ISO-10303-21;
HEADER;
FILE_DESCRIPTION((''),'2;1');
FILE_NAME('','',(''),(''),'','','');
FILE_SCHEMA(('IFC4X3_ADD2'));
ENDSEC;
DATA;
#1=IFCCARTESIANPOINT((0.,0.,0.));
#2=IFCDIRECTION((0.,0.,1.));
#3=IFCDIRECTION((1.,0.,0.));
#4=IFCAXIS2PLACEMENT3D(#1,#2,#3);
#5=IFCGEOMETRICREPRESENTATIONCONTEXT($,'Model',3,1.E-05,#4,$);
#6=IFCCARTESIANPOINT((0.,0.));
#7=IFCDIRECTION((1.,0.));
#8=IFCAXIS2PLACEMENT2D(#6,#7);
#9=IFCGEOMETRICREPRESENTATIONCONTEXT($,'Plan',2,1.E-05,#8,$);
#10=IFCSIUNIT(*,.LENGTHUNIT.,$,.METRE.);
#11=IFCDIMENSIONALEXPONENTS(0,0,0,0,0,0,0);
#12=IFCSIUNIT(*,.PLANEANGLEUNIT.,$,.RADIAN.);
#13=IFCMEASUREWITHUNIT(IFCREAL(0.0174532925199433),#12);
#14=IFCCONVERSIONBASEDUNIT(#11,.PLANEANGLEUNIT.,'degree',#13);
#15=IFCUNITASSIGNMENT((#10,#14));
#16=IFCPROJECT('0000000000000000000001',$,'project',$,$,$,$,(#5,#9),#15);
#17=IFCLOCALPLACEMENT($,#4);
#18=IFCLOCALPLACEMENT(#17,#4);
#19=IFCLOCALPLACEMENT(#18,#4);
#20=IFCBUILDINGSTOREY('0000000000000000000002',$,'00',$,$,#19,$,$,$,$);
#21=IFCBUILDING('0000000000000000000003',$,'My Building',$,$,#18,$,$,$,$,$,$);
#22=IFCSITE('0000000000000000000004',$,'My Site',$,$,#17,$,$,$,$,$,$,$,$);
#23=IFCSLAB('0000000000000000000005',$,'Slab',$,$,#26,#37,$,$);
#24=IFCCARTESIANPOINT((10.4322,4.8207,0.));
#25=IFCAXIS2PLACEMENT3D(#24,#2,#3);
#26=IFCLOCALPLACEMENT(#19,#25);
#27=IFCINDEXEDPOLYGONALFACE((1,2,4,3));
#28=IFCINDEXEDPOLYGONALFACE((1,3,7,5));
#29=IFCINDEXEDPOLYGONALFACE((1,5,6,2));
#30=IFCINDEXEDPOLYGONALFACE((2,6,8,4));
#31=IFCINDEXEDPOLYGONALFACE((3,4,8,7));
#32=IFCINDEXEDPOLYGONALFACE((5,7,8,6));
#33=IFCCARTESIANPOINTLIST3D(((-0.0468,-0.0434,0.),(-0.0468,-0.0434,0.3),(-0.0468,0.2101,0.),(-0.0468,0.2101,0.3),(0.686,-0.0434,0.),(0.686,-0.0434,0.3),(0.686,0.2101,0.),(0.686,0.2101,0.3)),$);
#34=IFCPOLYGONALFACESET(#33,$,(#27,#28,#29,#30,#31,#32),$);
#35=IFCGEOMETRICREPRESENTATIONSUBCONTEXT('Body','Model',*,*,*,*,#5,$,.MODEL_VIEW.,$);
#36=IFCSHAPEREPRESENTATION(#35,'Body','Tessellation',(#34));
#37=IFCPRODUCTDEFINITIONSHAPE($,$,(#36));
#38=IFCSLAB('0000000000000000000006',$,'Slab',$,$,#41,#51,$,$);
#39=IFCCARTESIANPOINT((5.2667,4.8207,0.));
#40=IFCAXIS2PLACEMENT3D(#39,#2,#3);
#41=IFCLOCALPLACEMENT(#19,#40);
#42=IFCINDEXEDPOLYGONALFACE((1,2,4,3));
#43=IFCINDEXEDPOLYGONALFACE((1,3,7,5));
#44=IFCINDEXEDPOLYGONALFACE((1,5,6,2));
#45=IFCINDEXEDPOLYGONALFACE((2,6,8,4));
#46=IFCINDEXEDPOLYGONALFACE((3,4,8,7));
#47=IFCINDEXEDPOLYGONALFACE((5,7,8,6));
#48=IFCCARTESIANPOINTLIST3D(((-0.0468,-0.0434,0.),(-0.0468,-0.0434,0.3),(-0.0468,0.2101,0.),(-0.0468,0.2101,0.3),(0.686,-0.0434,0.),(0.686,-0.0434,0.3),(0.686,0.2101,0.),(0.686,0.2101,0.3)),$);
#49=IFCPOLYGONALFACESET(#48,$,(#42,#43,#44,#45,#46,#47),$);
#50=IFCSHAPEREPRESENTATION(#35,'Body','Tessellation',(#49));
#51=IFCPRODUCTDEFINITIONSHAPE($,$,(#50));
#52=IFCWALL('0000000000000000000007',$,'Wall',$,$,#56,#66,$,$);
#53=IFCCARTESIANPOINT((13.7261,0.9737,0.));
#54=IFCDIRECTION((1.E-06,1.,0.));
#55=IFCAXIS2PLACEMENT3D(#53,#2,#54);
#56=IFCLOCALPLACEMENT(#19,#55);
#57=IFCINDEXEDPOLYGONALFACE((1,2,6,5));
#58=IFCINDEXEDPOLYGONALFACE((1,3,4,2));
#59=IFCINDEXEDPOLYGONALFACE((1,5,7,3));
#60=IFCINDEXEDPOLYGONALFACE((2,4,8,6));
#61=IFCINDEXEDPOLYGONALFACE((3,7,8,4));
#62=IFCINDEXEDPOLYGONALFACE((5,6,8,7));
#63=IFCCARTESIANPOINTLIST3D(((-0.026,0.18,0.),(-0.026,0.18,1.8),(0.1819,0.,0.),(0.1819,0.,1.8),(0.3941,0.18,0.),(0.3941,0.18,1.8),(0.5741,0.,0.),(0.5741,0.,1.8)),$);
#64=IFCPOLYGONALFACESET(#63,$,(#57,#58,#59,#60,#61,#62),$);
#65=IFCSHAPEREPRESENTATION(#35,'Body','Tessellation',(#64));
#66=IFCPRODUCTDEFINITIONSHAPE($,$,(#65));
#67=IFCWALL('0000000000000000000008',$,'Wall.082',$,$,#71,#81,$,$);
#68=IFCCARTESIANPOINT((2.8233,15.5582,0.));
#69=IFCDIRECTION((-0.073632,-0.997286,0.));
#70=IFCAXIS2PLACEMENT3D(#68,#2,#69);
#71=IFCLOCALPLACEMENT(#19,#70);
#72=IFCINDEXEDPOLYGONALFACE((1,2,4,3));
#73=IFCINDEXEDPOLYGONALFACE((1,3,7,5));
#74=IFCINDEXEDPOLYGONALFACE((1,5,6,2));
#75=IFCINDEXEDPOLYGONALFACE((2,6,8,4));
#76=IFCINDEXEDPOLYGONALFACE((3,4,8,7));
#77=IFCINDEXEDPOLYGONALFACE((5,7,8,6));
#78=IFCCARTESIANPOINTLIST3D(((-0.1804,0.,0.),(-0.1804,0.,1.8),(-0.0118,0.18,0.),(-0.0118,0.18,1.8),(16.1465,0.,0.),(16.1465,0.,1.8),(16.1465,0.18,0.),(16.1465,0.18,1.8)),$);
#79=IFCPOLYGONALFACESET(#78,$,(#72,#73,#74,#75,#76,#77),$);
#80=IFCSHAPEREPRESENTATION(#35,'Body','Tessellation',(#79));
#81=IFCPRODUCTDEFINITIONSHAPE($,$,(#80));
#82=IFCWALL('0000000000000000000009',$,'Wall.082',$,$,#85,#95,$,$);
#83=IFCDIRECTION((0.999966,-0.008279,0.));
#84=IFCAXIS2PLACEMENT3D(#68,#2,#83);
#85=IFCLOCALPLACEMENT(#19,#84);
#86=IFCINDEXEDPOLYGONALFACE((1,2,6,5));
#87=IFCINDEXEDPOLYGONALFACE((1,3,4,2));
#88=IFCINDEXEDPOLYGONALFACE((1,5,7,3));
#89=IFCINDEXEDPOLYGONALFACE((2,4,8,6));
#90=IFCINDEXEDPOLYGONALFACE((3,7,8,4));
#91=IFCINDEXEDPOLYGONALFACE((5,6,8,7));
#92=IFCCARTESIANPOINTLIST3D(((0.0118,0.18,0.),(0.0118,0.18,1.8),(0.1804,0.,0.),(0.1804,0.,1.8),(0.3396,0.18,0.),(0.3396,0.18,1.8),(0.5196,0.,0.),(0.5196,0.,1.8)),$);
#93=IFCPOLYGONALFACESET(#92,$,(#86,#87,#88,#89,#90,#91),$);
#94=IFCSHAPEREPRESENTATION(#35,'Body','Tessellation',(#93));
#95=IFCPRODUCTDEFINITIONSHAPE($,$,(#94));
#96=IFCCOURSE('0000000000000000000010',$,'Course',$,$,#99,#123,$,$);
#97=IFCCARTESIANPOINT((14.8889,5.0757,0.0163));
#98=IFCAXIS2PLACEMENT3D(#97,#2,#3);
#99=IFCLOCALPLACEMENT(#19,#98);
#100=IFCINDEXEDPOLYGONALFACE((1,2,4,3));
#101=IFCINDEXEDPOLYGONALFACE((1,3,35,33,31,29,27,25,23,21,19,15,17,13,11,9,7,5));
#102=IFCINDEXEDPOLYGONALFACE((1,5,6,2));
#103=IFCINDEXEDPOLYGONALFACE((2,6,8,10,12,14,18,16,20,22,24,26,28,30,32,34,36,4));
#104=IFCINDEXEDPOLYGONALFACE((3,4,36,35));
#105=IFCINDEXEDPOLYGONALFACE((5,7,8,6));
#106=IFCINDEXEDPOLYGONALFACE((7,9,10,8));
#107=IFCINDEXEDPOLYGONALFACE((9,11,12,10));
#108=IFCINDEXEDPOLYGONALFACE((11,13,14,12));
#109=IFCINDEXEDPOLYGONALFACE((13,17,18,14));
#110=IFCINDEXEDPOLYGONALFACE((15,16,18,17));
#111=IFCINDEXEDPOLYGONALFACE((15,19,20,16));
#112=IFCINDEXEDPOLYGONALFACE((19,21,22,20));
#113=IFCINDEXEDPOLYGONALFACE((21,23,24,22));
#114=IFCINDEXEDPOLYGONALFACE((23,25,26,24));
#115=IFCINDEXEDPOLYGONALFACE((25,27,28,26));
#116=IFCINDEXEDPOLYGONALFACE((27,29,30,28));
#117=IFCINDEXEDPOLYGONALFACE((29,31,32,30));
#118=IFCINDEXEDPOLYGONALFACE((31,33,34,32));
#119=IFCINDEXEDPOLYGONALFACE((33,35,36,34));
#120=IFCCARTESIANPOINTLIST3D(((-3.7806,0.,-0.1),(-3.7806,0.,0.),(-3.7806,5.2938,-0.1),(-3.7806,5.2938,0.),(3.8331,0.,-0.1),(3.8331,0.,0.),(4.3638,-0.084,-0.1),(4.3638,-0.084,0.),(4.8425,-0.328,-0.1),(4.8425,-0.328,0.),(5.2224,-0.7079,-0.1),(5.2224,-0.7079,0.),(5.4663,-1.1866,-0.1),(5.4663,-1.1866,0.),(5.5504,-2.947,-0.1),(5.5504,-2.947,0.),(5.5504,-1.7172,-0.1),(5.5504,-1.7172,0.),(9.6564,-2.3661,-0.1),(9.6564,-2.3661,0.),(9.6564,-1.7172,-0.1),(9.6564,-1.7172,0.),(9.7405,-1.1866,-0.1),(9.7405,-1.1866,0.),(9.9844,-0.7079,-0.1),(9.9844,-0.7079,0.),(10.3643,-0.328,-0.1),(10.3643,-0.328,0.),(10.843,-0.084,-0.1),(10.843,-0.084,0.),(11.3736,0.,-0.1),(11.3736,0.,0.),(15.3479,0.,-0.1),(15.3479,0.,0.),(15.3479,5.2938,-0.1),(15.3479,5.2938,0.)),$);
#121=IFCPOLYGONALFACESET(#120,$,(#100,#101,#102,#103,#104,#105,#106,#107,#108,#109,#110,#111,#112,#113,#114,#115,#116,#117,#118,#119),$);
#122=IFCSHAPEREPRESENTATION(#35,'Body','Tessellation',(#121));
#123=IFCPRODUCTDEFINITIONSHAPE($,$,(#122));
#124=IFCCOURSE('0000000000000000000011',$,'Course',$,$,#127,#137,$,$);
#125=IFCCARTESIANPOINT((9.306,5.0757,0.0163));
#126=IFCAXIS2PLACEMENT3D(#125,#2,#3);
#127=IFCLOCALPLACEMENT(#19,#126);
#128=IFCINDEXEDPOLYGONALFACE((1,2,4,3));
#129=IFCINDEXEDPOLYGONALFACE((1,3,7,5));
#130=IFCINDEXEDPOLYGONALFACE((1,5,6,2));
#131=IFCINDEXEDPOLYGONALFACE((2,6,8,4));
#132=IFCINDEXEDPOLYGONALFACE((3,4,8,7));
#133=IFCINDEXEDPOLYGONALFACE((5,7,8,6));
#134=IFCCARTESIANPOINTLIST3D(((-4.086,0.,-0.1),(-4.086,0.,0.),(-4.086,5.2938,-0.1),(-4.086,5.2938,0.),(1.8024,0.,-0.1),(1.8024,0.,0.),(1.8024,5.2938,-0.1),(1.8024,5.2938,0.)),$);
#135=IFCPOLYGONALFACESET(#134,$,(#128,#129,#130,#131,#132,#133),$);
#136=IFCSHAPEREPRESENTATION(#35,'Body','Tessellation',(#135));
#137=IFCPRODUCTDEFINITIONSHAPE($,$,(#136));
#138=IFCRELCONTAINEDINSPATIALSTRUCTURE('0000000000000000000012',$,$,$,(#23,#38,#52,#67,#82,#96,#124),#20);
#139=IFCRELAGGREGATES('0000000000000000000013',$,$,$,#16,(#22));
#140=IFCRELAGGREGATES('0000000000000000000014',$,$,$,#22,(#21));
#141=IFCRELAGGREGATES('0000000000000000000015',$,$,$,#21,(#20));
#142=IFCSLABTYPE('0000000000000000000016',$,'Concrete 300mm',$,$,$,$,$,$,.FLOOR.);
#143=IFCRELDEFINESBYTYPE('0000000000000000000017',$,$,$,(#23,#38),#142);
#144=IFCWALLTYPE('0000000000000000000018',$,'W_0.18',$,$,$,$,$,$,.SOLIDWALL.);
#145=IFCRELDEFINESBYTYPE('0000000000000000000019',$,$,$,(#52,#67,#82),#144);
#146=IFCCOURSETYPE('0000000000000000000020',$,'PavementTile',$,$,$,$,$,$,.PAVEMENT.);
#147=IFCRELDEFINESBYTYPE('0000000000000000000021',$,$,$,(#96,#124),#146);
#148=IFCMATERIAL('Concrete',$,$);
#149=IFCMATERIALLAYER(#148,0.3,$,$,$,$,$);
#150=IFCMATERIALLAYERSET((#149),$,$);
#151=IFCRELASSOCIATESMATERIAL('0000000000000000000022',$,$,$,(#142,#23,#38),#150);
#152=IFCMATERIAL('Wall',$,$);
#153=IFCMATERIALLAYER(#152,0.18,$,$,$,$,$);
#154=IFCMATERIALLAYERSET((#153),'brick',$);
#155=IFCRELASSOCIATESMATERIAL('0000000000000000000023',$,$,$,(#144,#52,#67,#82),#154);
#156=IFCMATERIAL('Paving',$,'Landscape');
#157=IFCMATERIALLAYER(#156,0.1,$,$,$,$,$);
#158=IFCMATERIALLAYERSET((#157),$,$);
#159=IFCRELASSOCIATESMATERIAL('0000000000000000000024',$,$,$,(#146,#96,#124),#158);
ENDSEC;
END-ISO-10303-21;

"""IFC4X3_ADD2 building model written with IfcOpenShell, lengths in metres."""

from ifc_helpers import new_model, entity, si_unit, converted_unit, frame, origin_with_axes, origin_2d_with_axis, place, context, subcontext, project, spatial, line, indexed_curve, outline, extrude, material, layer, layer_set, layer_usage, type_object, element, save


model = new_model("IFC4X3_ADD2")

# Units and contexts
model_context = context("Model", 3, precision=1e-05, world=origin_with_axes())
plan_context = context("Plan", 2, precision=1e-05, world=origin_2d_with_axis())
body_context_1 = subcontext(model_context, "Body", "Model", "MODEL_VIEW")
ifc_project = project(units=[si_unit("LENGTHUNIT", "METRE"), converted_unit("PLANEANGLEUNIT", "degree", entity("IfcReal", 0.0174532925199433), si_unit("PLANEANGLEUNIT", "RADIAN"), dimensions=[0, 0, 0, 0, 0, 0, 0])], contexts=[model_context, plan_context])

# Site, building, storey
site_placement = place(None, origin_with_axes())
site = spatial("IfcSite", under=ifc_project, at=site_placement, Name="My Site")
building_placement = place(site_placement, origin_with_axes())
building = spatial("IfcBuilding", under=site, at=building_placement, Name="My Building")
storey_placement = place(building_placement, origin_with_axes())
storey = spatial("IfcBuildingStorey", under=building, at=storey_placement, Name="00")

# Slabs
ifc_material_1 = material(Name="Concrete")
ifc_layer_1 = layer(ifc_material_1, 0.3)
ifc_layer_set_1 = layer_set([ifc_layer_1])
ifc_layer_usage_1 = layer_usage(ifc_layer_set_1, "AXIS3", "POSITIVE", 0.0)
slab_type = type_object("IfcSlabType", Name="Concrete 300mm", PredefinedType="FLOOR", material=ifc_layer_set_1)
slab_1_placement = place(storey_placement, frame((10.4322, 4.8207, 0.0), z_axis=(0.0, 0.0, 1.0), x_axis=(1.0, 0.0, 0.0)))
element("IfcSlab", 1, at=slab_1_placement, inside=storey, type_object=slab_type, material=ifc_layer_usage_1, Name="Slab", context=body_context_1, shape_type="SweptSolid", body=[
    extrude(outline(indexed_curve([(-0.0468, -0.0434), (0.686, -0.0434), (0.686, 0.2101), (-0.0468, 0.2101)], segments=[line(4, 1), line(1, 2), line(2, 3), line(3, 4)], self_intersect=False)), None, (0.0, 0.0, 1.0), 0.3),
])
ifc_layer_usage_2 = layer_usage(ifc_layer_set_1, "AXIS3", "POSITIVE", 0.0)
slab_2_placement = place(storey_placement, frame((5.2667, 4.8207, 0.0), z_axis=(0.0, 0.0, 1.0), x_axis=(1.0, 0.0, 0.0)))
element("IfcSlab", 2, at=slab_2_placement, inside=storey, type_object=slab_type, material=ifc_layer_usage_2, Name="Slab", context=body_context_1, shape_type="SweptSolid", body=[
    extrude(outline(indexed_curve([(-0.0468, 0.2101), (-0.0468, -0.0434), (0.686, -0.0434), (0.686, 0.2101)], segments=[line(4, 1), line(1, 2), line(2, 3), line(3, 4)], self_intersect=False)), None, (0.0, 0.0, 1.0), 0.3),
])

# Shared definitions
ifc_material_2 = material(Name="Wall")
ifc_layer_2 = layer(ifc_material_2, 0.18)
ifc_layer_set_2 = layer_set([ifc_layer_2], Name="brick")
wall_type_1 = type_object("IfcWallType", Name="W_0.18", PredefinedType="SOLIDWALL", material=ifc_layer_set_2)

# Wall
ifc_layer_usage_3 = layer_usage(ifc_layer_set_2, "AXIS2", "POSITIVE", 0.0)
wall_1_placement = place(storey_placement, frame((13.7261, 0.9737, 0.0), z_axis=(0.0, 0.0, 1.0), x_axis=(0.000001, 1.0, 0.0)))
element("IfcWall", 3, at=wall_1_placement, inside=storey, type_object=wall_type_1, material=ifc_layer_usage_3, Name="Wall", context=body_context_1, shape_type="SweptSolid", body=[
    extrude(outline(indexed_curve([(0.1819, 0.0), (-0.026, 0.18), (0.3941, 0.18), (0.5741, 0.0)], segments=[line(1, 2, 3, 4, 1)])), origin_with_axes(), (0.0, 0.0, 1.0), 1.8),
])

# Walls
ifc_layer_usage_4 = layer_usage(ifc_layer_set_2, "AXIS2", "POSITIVE", 0.0)
wall_2_placement = place(storey_placement, frame((2.8233, 15.5582, 0.0), z_axis=(0.0, 0.0, 1.0), x_axis=(-0.073632, -0.997286, 0.0)))
element("IfcWall", 4, at=wall_2_placement, inside=storey, type_object=wall_type_1, material=ifc_layer_usage_4, Name="Wall.082", context=body_context_1, shape_type="SweptSolid", body=[
    extrude(outline(indexed_curve([(-0.1804, 0.0), (-0.0118, 0.18), (16.1465, 0.18), (16.1465, 0.0)], segments=[line(1, 2, 3, 4, 1)])), origin_with_axes(), (0.0, 0.0, 1.0), 1.8),
])
ifc_layer_usage_5 = layer_usage(ifc_layer_set_2, "AXIS2", "POSITIVE", 0.0)
wall_3_placement = place(storey_placement, frame((2.8233, 15.5582, 0.0), z_axis=(0.0, 0.0, 1.0), x_axis=(0.999966, -0.008279, 0.0)))
element("IfcWall", 5, at=wall_3_placement, inside=storey, type_object=wall_type_1, material=ifc_layer_usage_5, Name="Wall.082", context=body_context_1, shape_type="SweptSolid", body=[
    extrude(outline(indexed_curve([(0.1804, 0.0), (0.0118, 0.18), (0.3396, 0.18), (0.5196, 0.0)], segments=[line(1, 2, 3, 4, 1)])), origin_with_axes(), (0.0, 0.0, 1.0), 1.8),
])

# Courses
ifc_material_3 = material(Name="Paving", Category="Landscape")
ifc_layer_3 = layer(ifc_material_3, 0.1)
ifc_layer_set_3 = layer_set([ifc_layer_3])
ifc_layer_usage_6 = layer_usage(ifc_layer_set_3, "AXIS3", "POSITIVE", -0.1)
course_type = type_object("IfcCourseType", Name="PavementTile", PredefinedType="PAVEMENT", material=ifc_layer_set_3)
course_1_placement = place(storey_placement, frame((14.8889, 5.0757, 0.0163), z_axis=(0.0, 0.0, 1.0), x_axis=(1.0, 0.0, 0.0)))
element("IfcCourse", 6, at=course_1_placement, inside=storey, type_object=course_type, material=ifc_layer_usage_6, Name="Course", context=body_context_1, shape_type="SweptSolid", body=[
    extrude(outline(indexed_curve([(15.3479, 0.0), (11.3736, 0.0), (10.843, -0.084), (10.3643, -0.328), (9.9844, -0.7079), (9.7405, -1.1866), (9.6564, -1.7172), (9.6564, -2.3661), (5.5504, -2.947), (5.5504, -1.7172), (5.4663, -1.1866), (5.2224, -0.7079), (4.8425, -0.328), (4.3638, -0.084), (3.8331, 0.0), (-3.7806, 0.0), (-3.7806, 5.2938), (15.3479, 5.2938), (15.3479, 0.0)])), frame((0.0, 0.0, -0.1), z_axis=(0.0, 0.0, 1.0), x_axis=(1.0, 0.0, 0.0)), (0.0, 0.0, 1.0), 0.1),
])
ifc_layer_usage_7 = layer_usage(ifc_layer_set_3, "AXIS3", "POSITIVE", -0.1)
course_2_placement = place(storey_placement, frame((9.306, 5.0757, 0.0163), z_axis=(0.0, 0.0, 1.0), x_axis=(1.0, 0.0, 0.0)))
element("IfcCourse", 7, at=course_2_placement, inside=storey, type_object=course_type, material=ifc_layer_usage_7, Name="Course", context=body_context_1, shape_type="SweptSolid", body=[
    extrude(outline(indexed_curve([(-4.086, 5.2938), (-4.086, 0.0), (1.8024, 0.0), (1.8024, 5.2938), (-4.086, 5.2938)])), frame((0.0, 0.0, -0.1), z_axis=(0.0, 0.0, 1.0), x_axis=(1.0, 0.0, 0.0)), (0.0, 0.0, 1.0), 0.1),
])

save(model, "model.ifc")
